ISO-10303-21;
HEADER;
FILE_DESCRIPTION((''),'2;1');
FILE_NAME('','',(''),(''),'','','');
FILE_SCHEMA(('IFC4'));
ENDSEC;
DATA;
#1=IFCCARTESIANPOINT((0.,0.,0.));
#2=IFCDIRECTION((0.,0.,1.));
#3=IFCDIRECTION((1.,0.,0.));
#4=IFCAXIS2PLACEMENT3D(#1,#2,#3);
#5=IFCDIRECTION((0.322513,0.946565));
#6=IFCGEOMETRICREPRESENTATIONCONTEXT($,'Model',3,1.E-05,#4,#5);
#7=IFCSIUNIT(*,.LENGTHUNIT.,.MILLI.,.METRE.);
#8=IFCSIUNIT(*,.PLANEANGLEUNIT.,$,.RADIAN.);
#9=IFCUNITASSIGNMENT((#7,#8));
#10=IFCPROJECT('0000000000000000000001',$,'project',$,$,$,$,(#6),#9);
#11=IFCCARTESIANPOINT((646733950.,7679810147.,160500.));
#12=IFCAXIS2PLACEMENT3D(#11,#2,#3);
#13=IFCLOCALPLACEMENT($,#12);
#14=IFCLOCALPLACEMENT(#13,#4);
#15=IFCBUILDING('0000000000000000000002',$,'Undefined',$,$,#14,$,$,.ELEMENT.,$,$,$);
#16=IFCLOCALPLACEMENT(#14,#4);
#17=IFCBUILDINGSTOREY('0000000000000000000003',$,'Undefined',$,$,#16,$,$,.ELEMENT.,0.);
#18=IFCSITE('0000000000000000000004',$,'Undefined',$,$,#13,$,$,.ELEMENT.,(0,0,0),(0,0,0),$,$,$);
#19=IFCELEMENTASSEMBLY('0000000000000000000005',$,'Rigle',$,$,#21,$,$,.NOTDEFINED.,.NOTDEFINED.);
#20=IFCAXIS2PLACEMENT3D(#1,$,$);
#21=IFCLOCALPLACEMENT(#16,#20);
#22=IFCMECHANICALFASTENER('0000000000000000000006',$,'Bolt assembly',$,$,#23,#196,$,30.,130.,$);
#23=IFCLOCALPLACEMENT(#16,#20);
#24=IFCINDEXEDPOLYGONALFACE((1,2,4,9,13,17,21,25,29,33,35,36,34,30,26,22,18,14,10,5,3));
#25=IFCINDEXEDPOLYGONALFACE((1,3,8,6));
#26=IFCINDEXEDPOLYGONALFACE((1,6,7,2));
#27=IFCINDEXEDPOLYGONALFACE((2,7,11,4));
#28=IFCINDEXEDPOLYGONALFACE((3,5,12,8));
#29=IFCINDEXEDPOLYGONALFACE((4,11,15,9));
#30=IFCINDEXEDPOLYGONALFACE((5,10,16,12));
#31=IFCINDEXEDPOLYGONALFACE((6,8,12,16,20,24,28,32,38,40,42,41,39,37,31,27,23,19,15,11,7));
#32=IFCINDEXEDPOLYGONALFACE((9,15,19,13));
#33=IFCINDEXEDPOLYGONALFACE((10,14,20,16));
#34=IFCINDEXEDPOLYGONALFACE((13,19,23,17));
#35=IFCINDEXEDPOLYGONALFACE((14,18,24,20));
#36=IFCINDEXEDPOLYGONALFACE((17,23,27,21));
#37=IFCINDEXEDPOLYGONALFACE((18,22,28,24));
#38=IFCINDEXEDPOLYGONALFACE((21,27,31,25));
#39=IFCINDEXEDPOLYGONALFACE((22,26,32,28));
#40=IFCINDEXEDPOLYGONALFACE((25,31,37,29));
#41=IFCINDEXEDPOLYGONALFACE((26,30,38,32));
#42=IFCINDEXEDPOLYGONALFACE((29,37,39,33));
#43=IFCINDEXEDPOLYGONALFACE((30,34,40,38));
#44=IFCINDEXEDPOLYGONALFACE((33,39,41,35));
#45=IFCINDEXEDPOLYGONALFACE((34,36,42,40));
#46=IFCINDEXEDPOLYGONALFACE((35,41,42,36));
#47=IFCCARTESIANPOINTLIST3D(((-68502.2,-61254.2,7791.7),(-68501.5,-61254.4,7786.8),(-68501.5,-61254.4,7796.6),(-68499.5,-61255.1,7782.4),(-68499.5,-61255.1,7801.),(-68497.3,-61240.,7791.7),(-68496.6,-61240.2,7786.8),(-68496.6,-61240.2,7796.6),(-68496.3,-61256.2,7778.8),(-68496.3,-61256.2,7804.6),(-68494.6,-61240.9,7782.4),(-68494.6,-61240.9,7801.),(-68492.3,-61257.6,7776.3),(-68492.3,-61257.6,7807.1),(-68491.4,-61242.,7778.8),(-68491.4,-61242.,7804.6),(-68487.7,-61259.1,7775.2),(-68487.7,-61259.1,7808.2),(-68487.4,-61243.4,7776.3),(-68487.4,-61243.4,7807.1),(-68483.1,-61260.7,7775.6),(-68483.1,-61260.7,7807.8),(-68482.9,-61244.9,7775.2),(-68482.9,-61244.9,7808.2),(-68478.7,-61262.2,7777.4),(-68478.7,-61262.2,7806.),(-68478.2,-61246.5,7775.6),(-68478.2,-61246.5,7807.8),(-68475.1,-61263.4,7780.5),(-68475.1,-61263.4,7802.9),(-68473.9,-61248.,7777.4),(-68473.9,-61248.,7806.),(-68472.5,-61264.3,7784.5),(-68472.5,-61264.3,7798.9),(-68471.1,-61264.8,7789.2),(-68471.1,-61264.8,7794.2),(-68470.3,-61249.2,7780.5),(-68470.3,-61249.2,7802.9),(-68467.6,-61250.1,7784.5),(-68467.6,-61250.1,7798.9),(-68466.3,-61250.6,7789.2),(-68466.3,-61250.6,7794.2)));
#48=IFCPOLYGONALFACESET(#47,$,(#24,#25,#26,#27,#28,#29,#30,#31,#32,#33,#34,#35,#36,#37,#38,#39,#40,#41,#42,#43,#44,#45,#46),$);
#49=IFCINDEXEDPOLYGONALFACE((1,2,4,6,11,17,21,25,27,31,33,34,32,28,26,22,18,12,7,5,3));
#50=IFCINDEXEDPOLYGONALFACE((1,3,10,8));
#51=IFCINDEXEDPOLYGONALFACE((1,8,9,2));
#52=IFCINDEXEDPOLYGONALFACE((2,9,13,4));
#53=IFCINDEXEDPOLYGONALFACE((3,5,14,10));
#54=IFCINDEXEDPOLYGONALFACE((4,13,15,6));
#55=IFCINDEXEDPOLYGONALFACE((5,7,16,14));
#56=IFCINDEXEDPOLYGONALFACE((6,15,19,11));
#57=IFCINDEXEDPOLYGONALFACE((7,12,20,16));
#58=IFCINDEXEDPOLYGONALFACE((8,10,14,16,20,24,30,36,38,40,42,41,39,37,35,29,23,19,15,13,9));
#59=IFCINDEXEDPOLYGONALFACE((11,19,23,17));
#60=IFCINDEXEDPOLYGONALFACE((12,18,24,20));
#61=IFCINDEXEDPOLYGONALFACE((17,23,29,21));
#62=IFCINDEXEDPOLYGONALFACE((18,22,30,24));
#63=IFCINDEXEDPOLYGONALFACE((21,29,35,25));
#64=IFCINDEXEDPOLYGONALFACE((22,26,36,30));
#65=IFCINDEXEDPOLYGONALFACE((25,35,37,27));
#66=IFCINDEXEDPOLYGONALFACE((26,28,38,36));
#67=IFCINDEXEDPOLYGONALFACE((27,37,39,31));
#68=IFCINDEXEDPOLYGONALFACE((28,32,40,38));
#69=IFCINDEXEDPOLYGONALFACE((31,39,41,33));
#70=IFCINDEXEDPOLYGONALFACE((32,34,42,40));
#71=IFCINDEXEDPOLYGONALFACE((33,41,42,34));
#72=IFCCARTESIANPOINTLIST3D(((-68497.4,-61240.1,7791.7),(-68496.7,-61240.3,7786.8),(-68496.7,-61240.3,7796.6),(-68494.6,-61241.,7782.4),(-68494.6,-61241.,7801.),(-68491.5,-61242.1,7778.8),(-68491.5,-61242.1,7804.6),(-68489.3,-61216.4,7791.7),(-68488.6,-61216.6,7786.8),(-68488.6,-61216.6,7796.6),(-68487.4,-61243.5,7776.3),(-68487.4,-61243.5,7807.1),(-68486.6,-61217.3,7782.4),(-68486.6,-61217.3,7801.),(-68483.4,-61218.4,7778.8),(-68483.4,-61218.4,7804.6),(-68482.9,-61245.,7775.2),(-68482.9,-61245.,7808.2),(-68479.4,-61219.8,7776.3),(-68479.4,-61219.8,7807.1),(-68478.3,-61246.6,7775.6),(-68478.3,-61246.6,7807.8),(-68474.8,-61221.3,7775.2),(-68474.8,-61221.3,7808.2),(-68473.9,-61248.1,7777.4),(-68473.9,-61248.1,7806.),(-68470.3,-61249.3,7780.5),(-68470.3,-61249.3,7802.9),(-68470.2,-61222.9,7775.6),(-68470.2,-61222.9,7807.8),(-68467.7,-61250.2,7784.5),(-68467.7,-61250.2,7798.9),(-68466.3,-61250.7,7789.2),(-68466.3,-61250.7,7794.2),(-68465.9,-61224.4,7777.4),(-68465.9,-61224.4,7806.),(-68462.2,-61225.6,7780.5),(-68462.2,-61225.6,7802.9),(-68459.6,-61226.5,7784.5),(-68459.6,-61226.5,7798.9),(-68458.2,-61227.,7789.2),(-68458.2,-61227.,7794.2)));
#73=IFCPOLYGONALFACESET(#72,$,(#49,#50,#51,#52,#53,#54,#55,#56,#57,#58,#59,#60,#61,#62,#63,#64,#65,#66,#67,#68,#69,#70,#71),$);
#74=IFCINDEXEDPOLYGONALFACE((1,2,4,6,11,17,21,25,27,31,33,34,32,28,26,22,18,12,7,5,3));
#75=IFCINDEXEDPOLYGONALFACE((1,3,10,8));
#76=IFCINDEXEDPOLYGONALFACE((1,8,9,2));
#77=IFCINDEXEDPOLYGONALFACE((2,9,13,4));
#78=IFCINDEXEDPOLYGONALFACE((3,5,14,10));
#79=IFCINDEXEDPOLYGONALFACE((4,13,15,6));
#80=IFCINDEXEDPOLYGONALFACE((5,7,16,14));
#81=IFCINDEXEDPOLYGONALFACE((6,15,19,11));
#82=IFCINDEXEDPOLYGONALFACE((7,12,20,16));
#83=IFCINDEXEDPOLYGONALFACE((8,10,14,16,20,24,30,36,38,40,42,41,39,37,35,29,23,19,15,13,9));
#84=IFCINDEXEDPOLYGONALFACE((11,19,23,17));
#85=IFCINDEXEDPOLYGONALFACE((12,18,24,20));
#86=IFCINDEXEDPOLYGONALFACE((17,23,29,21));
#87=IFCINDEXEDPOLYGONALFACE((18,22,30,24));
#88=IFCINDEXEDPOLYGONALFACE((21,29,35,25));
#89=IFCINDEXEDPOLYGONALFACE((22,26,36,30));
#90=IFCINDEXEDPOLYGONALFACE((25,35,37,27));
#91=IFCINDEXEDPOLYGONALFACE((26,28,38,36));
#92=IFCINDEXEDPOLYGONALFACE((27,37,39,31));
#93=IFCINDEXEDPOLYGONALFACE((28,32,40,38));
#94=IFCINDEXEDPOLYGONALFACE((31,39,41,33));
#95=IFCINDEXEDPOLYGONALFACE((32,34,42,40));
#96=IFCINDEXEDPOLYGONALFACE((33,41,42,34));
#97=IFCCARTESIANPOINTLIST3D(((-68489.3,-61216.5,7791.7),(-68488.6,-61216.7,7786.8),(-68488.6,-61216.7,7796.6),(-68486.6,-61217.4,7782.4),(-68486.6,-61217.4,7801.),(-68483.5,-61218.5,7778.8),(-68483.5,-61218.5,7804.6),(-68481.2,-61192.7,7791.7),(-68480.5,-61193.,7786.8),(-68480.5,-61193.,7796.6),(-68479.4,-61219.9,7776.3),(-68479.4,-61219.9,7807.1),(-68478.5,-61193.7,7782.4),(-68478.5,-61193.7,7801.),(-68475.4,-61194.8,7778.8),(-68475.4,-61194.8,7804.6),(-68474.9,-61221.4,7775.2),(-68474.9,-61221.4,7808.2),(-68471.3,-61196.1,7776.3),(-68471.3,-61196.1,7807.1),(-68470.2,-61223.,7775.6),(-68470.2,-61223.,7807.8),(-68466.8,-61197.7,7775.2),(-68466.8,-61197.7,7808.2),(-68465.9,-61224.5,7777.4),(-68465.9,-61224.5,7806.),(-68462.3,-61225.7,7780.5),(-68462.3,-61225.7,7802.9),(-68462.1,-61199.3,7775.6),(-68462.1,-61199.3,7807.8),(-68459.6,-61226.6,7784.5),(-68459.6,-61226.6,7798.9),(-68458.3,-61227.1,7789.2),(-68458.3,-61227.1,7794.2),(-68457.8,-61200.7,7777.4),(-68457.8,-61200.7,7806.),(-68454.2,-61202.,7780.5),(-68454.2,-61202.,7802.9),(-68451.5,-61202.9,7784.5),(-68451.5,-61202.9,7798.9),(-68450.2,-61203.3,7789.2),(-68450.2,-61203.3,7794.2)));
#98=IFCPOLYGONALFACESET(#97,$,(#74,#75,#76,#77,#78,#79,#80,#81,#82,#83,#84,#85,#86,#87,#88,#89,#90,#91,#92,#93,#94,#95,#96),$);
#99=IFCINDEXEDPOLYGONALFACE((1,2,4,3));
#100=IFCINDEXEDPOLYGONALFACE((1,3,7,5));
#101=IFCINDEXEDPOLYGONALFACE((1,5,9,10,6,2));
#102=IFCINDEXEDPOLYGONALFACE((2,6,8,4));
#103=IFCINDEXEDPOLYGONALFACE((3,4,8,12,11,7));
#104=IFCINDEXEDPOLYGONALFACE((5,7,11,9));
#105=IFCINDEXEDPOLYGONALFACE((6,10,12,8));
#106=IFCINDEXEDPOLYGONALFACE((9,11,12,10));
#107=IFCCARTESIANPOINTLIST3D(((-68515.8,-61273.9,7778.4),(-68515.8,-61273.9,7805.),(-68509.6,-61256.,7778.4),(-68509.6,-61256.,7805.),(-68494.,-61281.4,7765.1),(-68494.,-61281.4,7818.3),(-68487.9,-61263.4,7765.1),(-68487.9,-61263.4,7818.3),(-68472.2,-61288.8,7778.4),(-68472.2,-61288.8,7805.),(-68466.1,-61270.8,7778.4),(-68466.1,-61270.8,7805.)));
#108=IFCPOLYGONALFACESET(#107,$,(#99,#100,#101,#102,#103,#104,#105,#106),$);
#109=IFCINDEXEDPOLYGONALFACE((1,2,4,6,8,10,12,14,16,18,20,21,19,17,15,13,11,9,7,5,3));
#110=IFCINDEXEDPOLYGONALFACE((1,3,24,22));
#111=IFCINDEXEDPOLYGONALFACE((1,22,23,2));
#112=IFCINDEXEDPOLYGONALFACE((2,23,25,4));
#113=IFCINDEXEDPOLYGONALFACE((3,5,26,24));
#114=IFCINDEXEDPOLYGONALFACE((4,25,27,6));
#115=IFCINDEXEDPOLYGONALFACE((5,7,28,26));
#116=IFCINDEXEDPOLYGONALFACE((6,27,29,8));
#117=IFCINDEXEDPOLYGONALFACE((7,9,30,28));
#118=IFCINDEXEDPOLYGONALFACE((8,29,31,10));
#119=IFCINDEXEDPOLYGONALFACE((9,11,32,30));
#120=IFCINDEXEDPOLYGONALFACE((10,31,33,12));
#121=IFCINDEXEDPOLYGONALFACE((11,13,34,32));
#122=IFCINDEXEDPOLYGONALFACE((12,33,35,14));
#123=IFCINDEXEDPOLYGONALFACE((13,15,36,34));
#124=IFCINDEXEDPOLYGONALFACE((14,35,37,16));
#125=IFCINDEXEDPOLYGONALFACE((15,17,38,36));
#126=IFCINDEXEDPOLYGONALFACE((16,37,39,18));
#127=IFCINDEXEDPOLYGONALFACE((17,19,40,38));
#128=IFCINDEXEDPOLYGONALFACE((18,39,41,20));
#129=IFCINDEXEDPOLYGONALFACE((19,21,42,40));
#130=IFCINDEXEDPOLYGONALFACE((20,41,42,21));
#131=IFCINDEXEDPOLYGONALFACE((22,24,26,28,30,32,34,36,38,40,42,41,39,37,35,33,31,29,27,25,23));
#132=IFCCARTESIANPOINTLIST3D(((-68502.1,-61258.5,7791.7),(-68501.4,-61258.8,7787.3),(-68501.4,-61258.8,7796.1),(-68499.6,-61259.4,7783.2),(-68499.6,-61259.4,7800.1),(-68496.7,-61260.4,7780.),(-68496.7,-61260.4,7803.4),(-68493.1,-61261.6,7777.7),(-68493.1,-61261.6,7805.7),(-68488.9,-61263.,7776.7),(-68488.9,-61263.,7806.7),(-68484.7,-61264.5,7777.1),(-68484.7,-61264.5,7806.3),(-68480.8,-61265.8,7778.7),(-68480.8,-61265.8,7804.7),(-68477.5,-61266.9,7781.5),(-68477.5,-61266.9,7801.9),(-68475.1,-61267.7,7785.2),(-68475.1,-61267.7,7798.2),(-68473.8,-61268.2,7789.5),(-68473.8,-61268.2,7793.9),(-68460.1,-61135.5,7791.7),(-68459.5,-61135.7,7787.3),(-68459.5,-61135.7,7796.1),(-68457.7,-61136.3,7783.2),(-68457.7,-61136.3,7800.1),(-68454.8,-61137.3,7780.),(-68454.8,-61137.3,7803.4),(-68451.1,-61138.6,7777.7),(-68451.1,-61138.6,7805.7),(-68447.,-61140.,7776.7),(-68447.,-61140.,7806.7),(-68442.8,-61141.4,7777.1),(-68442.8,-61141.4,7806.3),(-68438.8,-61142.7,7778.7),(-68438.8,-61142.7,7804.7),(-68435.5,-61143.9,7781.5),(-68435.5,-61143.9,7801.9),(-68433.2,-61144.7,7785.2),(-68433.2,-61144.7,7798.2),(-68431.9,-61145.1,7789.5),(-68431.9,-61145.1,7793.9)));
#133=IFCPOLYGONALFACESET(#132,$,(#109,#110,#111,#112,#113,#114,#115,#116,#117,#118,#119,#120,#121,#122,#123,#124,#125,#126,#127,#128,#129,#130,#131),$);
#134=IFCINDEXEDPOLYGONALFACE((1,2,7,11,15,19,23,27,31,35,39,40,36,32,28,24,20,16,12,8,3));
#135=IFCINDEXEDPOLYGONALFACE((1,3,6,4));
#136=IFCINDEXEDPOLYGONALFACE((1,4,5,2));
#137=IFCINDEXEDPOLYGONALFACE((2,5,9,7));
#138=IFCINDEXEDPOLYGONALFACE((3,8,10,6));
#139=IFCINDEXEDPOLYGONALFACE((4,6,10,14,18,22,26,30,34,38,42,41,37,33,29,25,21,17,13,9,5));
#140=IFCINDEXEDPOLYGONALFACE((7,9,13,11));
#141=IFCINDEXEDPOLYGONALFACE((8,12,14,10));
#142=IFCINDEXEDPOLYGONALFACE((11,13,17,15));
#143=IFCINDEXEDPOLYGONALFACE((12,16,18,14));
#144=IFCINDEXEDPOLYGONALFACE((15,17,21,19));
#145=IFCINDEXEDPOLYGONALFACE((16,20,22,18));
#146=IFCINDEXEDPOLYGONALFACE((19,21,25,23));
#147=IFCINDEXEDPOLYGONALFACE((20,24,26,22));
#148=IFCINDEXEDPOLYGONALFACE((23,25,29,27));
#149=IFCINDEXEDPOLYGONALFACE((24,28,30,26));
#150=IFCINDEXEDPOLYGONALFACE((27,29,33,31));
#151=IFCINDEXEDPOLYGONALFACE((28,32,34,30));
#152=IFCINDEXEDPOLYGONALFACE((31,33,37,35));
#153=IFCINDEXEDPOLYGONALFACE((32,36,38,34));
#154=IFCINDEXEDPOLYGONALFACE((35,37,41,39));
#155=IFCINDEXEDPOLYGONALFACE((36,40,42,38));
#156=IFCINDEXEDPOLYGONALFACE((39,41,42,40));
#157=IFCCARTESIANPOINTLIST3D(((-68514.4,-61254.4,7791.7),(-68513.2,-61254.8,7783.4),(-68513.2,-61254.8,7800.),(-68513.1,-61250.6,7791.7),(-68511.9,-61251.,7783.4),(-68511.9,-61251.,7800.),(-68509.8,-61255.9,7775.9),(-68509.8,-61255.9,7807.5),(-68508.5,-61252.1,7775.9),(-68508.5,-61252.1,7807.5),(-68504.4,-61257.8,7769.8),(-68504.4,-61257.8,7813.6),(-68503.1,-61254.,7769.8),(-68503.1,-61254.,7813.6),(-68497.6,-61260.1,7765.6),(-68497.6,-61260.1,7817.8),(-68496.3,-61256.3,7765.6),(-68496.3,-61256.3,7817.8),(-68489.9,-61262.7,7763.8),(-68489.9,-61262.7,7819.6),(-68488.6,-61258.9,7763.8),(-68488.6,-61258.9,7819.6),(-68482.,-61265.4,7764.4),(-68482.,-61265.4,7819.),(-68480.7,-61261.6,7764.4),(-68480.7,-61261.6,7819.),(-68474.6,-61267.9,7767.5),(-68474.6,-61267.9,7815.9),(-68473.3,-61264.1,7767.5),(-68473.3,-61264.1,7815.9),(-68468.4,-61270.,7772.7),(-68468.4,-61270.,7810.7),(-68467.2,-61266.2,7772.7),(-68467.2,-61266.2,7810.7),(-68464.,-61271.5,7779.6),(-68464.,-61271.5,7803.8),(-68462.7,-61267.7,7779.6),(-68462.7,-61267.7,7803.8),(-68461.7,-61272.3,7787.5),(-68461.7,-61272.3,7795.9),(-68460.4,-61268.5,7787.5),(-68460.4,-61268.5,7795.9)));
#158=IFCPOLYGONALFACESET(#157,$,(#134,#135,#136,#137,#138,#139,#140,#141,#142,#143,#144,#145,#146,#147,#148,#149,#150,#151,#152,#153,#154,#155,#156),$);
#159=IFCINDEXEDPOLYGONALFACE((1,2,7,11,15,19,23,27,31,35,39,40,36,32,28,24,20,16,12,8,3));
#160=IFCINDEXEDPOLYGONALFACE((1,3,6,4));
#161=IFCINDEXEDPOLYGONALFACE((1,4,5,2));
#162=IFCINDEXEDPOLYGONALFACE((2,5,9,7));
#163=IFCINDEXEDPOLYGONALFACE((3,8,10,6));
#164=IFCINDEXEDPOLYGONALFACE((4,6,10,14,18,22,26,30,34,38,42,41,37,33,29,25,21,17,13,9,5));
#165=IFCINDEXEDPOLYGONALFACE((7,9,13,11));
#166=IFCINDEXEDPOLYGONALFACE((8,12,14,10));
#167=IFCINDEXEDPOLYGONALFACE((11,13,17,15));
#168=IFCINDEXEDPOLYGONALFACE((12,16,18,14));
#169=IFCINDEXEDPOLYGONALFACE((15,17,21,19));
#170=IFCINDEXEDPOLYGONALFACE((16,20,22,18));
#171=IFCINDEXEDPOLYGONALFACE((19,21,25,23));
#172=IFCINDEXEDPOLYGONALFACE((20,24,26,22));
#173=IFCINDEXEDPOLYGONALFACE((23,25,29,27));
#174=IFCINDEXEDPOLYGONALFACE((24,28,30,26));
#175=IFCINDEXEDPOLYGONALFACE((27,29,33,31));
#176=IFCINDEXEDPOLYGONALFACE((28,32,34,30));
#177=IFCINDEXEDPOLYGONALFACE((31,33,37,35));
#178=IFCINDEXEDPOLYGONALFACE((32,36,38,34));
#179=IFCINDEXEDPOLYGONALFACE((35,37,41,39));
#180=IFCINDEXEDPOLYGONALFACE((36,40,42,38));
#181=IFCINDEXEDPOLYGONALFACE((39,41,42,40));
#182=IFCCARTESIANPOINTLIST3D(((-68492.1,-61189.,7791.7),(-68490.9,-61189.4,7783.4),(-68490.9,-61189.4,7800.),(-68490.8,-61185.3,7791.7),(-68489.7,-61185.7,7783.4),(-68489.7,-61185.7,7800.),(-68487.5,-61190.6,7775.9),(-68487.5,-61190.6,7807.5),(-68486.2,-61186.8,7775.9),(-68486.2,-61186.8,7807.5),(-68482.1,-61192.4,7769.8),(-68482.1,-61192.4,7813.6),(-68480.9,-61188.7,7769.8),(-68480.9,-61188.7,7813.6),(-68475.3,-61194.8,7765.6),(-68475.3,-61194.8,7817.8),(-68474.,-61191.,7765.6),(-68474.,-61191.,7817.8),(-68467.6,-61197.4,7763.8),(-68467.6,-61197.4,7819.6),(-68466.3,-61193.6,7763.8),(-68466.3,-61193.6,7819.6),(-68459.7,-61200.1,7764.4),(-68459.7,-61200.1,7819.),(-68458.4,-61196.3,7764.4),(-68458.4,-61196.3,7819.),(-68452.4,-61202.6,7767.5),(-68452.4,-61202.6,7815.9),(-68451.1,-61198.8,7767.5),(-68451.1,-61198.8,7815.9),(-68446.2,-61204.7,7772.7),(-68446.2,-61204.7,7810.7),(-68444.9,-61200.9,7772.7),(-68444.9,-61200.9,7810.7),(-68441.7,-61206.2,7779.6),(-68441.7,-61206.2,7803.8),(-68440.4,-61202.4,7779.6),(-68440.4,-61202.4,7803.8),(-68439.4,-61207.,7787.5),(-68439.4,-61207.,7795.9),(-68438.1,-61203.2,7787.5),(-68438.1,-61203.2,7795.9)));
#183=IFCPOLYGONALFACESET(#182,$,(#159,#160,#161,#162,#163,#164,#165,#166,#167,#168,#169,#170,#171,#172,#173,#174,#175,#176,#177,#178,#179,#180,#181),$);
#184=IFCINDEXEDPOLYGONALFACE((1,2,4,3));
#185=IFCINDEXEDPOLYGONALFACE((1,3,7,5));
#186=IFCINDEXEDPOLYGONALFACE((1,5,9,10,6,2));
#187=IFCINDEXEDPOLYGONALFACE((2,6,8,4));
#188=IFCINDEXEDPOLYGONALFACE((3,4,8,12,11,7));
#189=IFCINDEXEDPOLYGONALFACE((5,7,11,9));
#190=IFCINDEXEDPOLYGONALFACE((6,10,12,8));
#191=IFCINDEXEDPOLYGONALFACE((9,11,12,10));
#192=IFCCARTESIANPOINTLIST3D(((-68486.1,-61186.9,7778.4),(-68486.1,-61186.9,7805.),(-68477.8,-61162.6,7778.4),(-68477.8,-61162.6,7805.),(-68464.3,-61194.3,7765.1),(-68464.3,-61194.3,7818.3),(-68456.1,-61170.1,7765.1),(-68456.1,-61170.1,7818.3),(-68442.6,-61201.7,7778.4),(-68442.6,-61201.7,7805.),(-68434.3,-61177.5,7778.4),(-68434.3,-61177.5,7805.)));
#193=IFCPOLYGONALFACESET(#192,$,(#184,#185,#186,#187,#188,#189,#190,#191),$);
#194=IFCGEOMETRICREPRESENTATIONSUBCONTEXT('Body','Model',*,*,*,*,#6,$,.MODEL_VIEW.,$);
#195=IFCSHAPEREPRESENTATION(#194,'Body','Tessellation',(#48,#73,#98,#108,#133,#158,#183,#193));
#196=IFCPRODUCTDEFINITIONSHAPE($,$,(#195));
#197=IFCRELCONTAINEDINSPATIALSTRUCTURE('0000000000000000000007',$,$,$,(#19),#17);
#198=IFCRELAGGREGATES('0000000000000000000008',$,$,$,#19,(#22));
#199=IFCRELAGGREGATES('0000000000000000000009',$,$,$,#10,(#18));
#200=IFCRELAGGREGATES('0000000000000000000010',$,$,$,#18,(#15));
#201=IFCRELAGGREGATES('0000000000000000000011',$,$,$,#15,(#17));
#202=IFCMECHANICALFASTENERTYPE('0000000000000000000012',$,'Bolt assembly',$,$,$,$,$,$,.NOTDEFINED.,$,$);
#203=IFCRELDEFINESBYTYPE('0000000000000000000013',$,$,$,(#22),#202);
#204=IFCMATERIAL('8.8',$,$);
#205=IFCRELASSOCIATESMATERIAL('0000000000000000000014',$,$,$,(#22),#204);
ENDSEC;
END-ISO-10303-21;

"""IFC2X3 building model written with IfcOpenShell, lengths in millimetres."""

from ifc_helpers import new_model, si_unit, direction, frame, origin_with_axes, origin_2d_with_axis, place, context, subcontext, project, spatial, polyline, circle, outline, extrude, source, transform, mapped, material, type_object, element, aggregate, save


model = new_model("IFC2X3")

# Units and contexts
model_context = context("Model", 3, precision=1e-05, world=origin_with_axes(), true_north=direction((0.322513, 0.946565)))
body_context = subcontext(model_context, "Body", "Model", "MODEL_VIEW")
ifc_project = project(units=[si_unit("LENGTHUNIT", "METRE", prefix="MILLI"), si_unit("PLANEANGLEUNIT", "RADIAN")], contexts=[model_context])

# Site, building, storey
site_placement = place(None, frame((646733950.0, 7679810147.0, 160500.0), z_axis=(0.0, 0.0, 1.0), x_axis=(1.0, 0.0, 0.0)))
site = spatial("IfcSite", under=ifc_project, at=site_placement, Name="Undefined", CompositionType="ELEMENT", RefLatitude=(0, 0, 0), RefLongitude=(0, 0, 0))
building_placement = place(site_placement, origin_with_axes())
building = spatial("IfcBuilding", under=site, at=building_placement, Name="Undefined", CompositionType="ELEMENT")
storey_placement = place(building_placement, origin_with_axes())
storey = spatial("IfcBuildingStorey", under=building, at=storey_placement, Name="Undefined", CompositionType="ELEMENT", Elevation=0.0)

# Shared definitions
ifc_material_1 = material(Name="8.8")
mechanical_fastener_type = type_object("IfcMechanicalFastenerType", Name="Bolt assembly")

# Element assembly, mechanical fastener
assembly_1_placement = place(storey_placement, origin_with_axes())
assembly_1 = element("IfcElementAssembly", 1, at=assembly_1_placement, inside=storey, Name="Rigle", AssemblyPlace="NOTDEFINED", PredefinedType="NOTDEFINED")
shared_shape_1 = source(origin_with_axes(), body_context, "Body", "SweptSolid", [
    extrude(circle(Radius=16.5, at=origin_2d_with_axis()), frame((0.0, -7.4, 0.0), z_axis=(0.0, 1.0, 0.0), x_axis=(1.0, 0.0, 0.0)), (0.0, 0.0, 1.0), 15.0),
    extrude(circle(Radius=16.5, at=origin_2d_with_axis()), frame((0.0, 7.5, 0.0), z_axis=(0.0, 1.0, 0.0), x_axis=(1.0, 0.0, 0.0)), (0.0, 0.0, 1.0), 25.0),
    extrude(circle(Radius=16.5, at=origin_2d_with_axis()), frame((0.0, 32.4, 0.0), z_axis=(0.0, 1.0, 0.0), x_axis=(1.0, 0.0, 0.0)), (0.0, 0.0, 1.0), 25.1),
    extrude(outline(polyline([(23.0, -13.3), (23.0, 13.3), (0.0, 26.6), (-23.0, 13.3), (-23.0, -13.3), (0.0, -26.6), (23.0, -13.3)])), frame((0.0, -30.5, 0.0), z_axis=(0.0, 1.0, 0.0), x_axis=(1.0, 0.0, 0.0)), (0.0, 0.0, 1.0), 19.0),
    extrude(circle(Radius=15.0, at=origin_2d_with_axis()), frame((0.0, -11.5, 0.0), z_axis=(0.0, 1.0, 0.0), x_axis=(1.0, 0.0, 0.0)), (0.0, 0.0, 1.0), 130.0),
    extrude(circle(Radius=28.0, at=origin_2d_with_axis()), frame((0.0, -11.5, 0.0), z_axis=(0.0, 1.0, 0.0), x_axis=(1.0, 0.0, 0.0)), (0.0, 0.0, 1.0), 4.0),
    extrude(circle(Radius=28.0, at=origin_2d_with_axis()), frame((0.0, 57.5, 0.0), z_axis=(0.0, 1.0, 0.0), x_axis=(1.0, 0.0, 0.0)), (0.0, 0.0, 1.0), 4.0),
    extrude(outline(polyline([(23.0, -13.3), (23.0, 13.3), (0.0, 26.6), (-23.0, 13.3), (-23.0, -13.3), (0.0, -26.6), (23.0, -13.3)])), frame((0.0, 61.5, 0.0), z_axis=(0.0, 1.0, 0.0), x_axis=(1.0, 0.0, 0.0)), (0.0, 0.0, 1.0), 25.6),
])
mechanical_fastener_1_placement = place(assembly_1_placement, frame((-68484.2, -61252.5, 7791.7), z_axis=(0.0, 0.0, -1.0), x_axis=(-0.946565, 0.322513, 0.0)))
mechanical_fastener_1 = element("IfcMechanicalFastener", 2, at=mechanical_fastener_1_placement, type_object=mechanical_fastener_type, material=ifc_material_1, Name="Bolt assembly", NominalDiameter=30.0, NominalLength=130.0, context=body_context, shape_type="MappedRepresentation", body=[
    mapped(shared_shape_1, transform((0.0, 0.0, 0.0))),
])
aggregate(assembly_1, [mechanical_fastener_1])

save(model, "model.ifc")
